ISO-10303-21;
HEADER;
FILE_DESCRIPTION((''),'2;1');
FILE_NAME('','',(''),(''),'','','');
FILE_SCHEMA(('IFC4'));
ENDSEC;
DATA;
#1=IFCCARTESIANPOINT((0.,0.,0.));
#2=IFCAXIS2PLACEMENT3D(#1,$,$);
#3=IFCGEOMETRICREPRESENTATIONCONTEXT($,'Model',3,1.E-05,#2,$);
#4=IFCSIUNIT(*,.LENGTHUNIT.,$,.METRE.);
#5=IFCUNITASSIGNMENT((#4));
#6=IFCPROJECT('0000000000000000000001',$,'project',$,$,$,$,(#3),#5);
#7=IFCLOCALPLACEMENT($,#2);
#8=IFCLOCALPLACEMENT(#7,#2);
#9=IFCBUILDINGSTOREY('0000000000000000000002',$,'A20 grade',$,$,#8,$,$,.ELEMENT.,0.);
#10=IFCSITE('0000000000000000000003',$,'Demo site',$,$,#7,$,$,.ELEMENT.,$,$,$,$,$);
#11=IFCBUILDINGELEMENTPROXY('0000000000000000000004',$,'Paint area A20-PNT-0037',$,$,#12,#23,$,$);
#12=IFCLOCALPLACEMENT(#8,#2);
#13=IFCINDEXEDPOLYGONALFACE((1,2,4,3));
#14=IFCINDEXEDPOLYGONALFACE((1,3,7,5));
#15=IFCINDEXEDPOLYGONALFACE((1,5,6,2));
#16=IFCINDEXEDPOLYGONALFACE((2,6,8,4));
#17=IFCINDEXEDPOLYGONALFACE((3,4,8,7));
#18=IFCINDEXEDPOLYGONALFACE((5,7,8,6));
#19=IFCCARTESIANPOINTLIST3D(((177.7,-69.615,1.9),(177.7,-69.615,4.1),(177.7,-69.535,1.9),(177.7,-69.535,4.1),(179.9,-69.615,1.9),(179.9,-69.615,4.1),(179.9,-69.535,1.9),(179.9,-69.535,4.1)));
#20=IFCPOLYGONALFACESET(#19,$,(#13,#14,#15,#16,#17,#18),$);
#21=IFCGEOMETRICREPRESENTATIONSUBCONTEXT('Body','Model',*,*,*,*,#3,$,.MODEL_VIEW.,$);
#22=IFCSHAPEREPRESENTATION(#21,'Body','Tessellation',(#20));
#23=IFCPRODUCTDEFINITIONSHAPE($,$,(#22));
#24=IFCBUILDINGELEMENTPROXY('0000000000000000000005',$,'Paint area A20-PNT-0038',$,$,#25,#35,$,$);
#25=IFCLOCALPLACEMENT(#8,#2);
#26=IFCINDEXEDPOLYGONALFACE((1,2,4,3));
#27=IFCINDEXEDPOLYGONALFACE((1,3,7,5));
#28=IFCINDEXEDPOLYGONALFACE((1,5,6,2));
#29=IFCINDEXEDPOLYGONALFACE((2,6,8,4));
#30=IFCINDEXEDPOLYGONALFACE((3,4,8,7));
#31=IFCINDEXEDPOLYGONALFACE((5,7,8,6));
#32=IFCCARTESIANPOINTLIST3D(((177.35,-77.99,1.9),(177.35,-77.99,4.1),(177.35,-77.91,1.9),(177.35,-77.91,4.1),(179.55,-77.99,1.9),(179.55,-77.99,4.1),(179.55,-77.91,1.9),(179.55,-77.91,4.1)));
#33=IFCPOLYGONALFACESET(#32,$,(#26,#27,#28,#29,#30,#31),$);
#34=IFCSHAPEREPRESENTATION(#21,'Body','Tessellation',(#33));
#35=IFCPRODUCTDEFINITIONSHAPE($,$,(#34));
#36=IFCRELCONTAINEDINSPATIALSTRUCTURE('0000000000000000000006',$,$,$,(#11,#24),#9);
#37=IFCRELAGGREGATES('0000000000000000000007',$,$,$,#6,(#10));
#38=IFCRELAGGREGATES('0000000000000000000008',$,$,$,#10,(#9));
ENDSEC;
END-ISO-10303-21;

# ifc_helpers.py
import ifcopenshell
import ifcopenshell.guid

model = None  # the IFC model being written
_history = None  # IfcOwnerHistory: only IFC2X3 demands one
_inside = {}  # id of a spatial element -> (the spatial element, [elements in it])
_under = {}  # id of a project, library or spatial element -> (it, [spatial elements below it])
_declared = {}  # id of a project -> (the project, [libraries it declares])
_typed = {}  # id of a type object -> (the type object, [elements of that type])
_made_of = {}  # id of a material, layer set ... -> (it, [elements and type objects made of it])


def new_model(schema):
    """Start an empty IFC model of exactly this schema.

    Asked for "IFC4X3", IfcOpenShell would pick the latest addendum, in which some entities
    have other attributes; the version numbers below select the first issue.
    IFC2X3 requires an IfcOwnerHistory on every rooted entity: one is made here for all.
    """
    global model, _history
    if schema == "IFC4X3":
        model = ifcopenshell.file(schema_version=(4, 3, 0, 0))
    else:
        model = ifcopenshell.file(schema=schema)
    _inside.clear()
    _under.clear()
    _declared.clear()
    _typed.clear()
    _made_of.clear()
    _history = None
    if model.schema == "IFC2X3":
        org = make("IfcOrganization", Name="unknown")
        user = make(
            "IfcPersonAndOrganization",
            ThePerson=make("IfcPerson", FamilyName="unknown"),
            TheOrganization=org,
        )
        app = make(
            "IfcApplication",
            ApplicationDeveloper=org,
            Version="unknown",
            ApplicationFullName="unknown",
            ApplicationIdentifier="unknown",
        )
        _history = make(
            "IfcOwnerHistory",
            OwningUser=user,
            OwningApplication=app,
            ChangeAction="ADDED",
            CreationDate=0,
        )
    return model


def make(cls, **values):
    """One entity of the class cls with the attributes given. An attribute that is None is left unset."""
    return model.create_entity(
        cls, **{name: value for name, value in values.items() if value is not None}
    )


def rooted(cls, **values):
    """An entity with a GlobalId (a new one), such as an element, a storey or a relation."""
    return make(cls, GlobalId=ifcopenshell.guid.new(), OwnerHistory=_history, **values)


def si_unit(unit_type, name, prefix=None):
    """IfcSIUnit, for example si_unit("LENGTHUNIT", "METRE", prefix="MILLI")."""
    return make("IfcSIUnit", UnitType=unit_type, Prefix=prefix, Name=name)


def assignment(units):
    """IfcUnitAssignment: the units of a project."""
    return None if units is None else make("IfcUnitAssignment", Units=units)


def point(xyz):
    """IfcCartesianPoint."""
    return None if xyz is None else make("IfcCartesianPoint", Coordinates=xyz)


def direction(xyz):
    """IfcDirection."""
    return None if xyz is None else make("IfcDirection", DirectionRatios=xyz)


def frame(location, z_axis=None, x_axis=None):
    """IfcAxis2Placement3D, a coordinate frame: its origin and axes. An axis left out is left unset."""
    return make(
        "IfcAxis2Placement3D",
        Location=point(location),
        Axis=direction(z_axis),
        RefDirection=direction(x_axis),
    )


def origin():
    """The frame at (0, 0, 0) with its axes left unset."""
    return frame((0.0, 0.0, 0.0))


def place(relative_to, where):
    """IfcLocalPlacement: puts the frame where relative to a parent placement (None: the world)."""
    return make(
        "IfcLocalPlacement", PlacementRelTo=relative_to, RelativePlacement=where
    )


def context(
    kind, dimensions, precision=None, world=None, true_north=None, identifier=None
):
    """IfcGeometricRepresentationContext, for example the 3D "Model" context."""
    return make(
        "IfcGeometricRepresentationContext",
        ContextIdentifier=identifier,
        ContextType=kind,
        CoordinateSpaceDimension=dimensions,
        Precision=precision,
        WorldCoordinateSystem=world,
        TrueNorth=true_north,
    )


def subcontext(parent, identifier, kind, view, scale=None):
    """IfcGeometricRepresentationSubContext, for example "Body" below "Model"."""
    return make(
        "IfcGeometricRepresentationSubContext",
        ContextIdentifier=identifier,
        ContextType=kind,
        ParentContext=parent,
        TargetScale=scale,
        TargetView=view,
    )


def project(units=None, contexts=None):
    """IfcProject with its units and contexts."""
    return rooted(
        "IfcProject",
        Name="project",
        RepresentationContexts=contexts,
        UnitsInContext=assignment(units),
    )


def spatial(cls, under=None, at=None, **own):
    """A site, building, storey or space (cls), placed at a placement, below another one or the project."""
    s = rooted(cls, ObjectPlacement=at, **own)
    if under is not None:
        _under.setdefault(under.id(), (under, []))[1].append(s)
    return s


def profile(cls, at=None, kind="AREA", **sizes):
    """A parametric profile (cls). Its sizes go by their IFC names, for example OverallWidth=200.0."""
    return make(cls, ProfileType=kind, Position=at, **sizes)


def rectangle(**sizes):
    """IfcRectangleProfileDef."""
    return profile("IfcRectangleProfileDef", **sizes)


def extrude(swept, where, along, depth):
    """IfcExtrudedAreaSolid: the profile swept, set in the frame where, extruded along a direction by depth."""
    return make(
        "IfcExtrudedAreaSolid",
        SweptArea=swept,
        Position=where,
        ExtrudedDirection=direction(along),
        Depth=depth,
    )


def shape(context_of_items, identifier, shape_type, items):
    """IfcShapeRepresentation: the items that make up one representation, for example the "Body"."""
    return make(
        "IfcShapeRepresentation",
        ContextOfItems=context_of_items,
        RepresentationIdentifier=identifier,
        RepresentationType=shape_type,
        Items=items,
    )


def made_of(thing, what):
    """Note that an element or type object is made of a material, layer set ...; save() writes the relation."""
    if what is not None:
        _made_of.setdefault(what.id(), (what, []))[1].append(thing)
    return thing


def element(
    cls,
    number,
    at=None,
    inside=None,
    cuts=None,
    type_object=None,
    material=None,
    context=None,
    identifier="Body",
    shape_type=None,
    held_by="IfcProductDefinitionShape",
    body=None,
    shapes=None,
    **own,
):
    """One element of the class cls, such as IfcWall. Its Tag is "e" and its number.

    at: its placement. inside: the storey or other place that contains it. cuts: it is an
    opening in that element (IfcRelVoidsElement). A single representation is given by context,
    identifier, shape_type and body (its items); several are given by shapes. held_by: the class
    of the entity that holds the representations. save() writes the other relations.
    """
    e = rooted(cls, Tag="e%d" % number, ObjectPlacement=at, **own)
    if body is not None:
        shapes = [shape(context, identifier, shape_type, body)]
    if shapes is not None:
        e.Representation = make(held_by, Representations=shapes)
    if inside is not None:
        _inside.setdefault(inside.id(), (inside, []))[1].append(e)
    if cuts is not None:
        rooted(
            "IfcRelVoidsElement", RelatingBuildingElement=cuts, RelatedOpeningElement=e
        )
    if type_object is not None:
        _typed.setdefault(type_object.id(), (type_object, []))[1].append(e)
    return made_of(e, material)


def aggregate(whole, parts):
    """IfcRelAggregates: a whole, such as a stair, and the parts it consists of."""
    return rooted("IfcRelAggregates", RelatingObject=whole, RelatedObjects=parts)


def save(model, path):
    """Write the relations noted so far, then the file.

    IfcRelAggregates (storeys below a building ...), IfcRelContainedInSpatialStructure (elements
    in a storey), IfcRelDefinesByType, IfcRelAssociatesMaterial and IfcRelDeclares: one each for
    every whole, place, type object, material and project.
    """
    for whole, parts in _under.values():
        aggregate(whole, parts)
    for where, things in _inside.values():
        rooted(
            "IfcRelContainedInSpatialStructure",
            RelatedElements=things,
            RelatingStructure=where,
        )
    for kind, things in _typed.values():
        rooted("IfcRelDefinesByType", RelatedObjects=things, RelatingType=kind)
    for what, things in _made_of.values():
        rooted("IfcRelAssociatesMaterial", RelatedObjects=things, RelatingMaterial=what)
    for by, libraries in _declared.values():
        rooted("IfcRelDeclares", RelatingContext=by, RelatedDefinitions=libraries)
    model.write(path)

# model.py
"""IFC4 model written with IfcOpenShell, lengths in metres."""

from ifc_helpers import new_model, si_unit, frame, origin, place, context, subcontext, project, spatial, rectangle, extrude, element, save


model = new_model("IFC4")

# Units and contexts
model_context = context("Model", 3, precision=1e-05, world=origin())
body_context = subcontext(model_context, "Body", "Model", "MODEL_VIEW")
ifc_project = project(units=[si_unit("LENGTHUNIT", "METRE")], contexts=[model_context])

# Site, storey
site_placement = place(None, origin())
site = spatial("IfcSite", under=ifc_project, at=site_placement, Name="Demo site", CompositionType="ELEMENT")
storey_placement = place(site_placement, origin())
storey = spatial("IfcBuildingStorey", under=site, at=storey_placement, Name="A20 grade", CompositionType="ELEMENT", Elevation=0.0)

# Building element proxies
for number, where, name in (
    (1, (178.8, -69.575, 1.9), "Paint area A20-PNT-0037"),
    (2, (178.45, -77.95, 1.9), "Paint area A20-PNT-0038"),
):
    element("IfcBuildingElementProxy", number, at=place(storey_placement, frame(where)), inside=storey, Name=name, context=body_context, shape_type="SweptSolid", body=[
        extrude(rectangle(XDim=2.2, YDim=0.08), origin(), (0.0, 0.0, 1.0), 2.2),
    ])

save(model, "model.ifc")
